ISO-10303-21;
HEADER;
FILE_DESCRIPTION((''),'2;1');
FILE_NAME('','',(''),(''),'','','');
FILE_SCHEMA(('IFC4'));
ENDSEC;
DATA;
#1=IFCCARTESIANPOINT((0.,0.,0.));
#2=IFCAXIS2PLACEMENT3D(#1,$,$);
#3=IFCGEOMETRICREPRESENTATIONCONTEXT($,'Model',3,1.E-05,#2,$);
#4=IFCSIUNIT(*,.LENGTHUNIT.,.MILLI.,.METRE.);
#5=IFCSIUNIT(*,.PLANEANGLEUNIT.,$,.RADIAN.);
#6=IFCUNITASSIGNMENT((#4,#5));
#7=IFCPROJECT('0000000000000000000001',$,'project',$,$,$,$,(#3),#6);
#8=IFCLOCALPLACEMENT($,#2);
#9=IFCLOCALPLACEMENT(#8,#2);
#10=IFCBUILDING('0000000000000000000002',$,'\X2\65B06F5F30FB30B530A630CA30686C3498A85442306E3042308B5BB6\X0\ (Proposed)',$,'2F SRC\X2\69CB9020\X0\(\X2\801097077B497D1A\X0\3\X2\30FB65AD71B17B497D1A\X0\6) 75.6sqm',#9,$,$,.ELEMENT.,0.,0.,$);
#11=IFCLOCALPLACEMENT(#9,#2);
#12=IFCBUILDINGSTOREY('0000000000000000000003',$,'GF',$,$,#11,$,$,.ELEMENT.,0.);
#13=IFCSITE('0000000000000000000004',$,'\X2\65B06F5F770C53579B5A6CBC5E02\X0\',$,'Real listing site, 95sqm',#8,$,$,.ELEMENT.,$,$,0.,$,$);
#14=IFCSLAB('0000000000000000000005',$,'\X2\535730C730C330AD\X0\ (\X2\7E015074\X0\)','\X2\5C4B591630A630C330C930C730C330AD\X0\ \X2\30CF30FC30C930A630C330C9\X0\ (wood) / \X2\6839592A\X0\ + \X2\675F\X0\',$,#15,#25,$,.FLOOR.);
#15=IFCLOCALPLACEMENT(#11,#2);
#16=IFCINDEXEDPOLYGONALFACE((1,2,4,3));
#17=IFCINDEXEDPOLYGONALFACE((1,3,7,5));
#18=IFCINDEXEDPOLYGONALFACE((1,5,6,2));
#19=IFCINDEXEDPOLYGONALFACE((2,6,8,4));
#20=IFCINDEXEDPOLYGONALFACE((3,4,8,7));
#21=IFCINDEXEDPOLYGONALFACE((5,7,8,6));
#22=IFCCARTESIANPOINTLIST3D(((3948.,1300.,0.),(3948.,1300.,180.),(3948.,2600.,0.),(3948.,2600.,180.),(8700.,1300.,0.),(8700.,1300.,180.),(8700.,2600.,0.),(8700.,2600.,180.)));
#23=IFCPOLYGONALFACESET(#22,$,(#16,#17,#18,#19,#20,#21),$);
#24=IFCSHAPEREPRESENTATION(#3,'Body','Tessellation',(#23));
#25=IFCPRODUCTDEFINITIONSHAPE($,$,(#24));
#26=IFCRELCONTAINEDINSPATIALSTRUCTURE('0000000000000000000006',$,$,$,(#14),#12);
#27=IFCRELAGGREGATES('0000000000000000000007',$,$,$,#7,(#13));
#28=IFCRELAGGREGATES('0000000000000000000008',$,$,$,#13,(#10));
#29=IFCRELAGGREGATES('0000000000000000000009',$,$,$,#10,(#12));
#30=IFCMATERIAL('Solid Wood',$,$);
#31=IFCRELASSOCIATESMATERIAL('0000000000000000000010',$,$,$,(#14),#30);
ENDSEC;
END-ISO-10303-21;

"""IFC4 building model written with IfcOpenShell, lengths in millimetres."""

from ifc_helpers import new_model, si_unit, frame, frame_2d, origin, place, context, project, spatial, rectangle, extrude, material, element, save


model = new_model("IFC4")

# Units and contexts
model_context = context("Model", 3, precision=1e-05, world=origin())
ifc_project = project(units=[si_unit("LENGTHUNIT", "METRE", prefix="MILLI"), si_unit("PLANEANGLEUNIT", "RADIAN")], contexts=[model_context])

# Site, building, storey
site_placement = place(None, origin())
site = spatial("IfcSite", under=ifc_project, at=site_placement, Name="新潟県南魚沼市", ObjectType="Real listing site, 95sqm", CompositionType="ELEMENT", RefElevation=0.0)
building_placement = place(site_placement, origin())
building = spatial("IfcBuilding", under=site, at=building_placement, Name="新潟・サウナと水風呂のある家 (Proposed)", ObjectType="2F SRC構造(耐震等級3・断熱等級6) 75.6sqm", CompositionType="ELEMENT", ElevationOfRefHeight=0.0, ElevationOfTerrain=0.0)
storey_placement = place(building_placement, origin())
storey = spatial("IfcBuildingStorey", under=building, at=storey_placement, Name="GF", CompositionType="ELEMENT", Elevation=0.0)

# Shared definitions
ifc_material_1 = material(Name="Solid Wood")

# Slab
slab_1_placement = place(storey_placement, frame((1974.0, 650.0, 0.0)))
element("IfcSlab", 1, at=slab_1_placement, inside=storey, material=ifc_material_1, Name="南デッキ (縁側)", Description="屋外ウッドデッキ ハードウッド (wood) / 根太 + 束", PredefinedType="FLOOR", context=model_context, shape_type="SweptSolid", body=[
    extrude(rectangle(XDim=4752.0, YDim=1300.0, at=frame_2d((2376.0, 650.0))), frame((1974.0, 650.0, 0.0)), (0.0, 0.0, 1.0), 180.0),
])

save(model, "model.ifc")
